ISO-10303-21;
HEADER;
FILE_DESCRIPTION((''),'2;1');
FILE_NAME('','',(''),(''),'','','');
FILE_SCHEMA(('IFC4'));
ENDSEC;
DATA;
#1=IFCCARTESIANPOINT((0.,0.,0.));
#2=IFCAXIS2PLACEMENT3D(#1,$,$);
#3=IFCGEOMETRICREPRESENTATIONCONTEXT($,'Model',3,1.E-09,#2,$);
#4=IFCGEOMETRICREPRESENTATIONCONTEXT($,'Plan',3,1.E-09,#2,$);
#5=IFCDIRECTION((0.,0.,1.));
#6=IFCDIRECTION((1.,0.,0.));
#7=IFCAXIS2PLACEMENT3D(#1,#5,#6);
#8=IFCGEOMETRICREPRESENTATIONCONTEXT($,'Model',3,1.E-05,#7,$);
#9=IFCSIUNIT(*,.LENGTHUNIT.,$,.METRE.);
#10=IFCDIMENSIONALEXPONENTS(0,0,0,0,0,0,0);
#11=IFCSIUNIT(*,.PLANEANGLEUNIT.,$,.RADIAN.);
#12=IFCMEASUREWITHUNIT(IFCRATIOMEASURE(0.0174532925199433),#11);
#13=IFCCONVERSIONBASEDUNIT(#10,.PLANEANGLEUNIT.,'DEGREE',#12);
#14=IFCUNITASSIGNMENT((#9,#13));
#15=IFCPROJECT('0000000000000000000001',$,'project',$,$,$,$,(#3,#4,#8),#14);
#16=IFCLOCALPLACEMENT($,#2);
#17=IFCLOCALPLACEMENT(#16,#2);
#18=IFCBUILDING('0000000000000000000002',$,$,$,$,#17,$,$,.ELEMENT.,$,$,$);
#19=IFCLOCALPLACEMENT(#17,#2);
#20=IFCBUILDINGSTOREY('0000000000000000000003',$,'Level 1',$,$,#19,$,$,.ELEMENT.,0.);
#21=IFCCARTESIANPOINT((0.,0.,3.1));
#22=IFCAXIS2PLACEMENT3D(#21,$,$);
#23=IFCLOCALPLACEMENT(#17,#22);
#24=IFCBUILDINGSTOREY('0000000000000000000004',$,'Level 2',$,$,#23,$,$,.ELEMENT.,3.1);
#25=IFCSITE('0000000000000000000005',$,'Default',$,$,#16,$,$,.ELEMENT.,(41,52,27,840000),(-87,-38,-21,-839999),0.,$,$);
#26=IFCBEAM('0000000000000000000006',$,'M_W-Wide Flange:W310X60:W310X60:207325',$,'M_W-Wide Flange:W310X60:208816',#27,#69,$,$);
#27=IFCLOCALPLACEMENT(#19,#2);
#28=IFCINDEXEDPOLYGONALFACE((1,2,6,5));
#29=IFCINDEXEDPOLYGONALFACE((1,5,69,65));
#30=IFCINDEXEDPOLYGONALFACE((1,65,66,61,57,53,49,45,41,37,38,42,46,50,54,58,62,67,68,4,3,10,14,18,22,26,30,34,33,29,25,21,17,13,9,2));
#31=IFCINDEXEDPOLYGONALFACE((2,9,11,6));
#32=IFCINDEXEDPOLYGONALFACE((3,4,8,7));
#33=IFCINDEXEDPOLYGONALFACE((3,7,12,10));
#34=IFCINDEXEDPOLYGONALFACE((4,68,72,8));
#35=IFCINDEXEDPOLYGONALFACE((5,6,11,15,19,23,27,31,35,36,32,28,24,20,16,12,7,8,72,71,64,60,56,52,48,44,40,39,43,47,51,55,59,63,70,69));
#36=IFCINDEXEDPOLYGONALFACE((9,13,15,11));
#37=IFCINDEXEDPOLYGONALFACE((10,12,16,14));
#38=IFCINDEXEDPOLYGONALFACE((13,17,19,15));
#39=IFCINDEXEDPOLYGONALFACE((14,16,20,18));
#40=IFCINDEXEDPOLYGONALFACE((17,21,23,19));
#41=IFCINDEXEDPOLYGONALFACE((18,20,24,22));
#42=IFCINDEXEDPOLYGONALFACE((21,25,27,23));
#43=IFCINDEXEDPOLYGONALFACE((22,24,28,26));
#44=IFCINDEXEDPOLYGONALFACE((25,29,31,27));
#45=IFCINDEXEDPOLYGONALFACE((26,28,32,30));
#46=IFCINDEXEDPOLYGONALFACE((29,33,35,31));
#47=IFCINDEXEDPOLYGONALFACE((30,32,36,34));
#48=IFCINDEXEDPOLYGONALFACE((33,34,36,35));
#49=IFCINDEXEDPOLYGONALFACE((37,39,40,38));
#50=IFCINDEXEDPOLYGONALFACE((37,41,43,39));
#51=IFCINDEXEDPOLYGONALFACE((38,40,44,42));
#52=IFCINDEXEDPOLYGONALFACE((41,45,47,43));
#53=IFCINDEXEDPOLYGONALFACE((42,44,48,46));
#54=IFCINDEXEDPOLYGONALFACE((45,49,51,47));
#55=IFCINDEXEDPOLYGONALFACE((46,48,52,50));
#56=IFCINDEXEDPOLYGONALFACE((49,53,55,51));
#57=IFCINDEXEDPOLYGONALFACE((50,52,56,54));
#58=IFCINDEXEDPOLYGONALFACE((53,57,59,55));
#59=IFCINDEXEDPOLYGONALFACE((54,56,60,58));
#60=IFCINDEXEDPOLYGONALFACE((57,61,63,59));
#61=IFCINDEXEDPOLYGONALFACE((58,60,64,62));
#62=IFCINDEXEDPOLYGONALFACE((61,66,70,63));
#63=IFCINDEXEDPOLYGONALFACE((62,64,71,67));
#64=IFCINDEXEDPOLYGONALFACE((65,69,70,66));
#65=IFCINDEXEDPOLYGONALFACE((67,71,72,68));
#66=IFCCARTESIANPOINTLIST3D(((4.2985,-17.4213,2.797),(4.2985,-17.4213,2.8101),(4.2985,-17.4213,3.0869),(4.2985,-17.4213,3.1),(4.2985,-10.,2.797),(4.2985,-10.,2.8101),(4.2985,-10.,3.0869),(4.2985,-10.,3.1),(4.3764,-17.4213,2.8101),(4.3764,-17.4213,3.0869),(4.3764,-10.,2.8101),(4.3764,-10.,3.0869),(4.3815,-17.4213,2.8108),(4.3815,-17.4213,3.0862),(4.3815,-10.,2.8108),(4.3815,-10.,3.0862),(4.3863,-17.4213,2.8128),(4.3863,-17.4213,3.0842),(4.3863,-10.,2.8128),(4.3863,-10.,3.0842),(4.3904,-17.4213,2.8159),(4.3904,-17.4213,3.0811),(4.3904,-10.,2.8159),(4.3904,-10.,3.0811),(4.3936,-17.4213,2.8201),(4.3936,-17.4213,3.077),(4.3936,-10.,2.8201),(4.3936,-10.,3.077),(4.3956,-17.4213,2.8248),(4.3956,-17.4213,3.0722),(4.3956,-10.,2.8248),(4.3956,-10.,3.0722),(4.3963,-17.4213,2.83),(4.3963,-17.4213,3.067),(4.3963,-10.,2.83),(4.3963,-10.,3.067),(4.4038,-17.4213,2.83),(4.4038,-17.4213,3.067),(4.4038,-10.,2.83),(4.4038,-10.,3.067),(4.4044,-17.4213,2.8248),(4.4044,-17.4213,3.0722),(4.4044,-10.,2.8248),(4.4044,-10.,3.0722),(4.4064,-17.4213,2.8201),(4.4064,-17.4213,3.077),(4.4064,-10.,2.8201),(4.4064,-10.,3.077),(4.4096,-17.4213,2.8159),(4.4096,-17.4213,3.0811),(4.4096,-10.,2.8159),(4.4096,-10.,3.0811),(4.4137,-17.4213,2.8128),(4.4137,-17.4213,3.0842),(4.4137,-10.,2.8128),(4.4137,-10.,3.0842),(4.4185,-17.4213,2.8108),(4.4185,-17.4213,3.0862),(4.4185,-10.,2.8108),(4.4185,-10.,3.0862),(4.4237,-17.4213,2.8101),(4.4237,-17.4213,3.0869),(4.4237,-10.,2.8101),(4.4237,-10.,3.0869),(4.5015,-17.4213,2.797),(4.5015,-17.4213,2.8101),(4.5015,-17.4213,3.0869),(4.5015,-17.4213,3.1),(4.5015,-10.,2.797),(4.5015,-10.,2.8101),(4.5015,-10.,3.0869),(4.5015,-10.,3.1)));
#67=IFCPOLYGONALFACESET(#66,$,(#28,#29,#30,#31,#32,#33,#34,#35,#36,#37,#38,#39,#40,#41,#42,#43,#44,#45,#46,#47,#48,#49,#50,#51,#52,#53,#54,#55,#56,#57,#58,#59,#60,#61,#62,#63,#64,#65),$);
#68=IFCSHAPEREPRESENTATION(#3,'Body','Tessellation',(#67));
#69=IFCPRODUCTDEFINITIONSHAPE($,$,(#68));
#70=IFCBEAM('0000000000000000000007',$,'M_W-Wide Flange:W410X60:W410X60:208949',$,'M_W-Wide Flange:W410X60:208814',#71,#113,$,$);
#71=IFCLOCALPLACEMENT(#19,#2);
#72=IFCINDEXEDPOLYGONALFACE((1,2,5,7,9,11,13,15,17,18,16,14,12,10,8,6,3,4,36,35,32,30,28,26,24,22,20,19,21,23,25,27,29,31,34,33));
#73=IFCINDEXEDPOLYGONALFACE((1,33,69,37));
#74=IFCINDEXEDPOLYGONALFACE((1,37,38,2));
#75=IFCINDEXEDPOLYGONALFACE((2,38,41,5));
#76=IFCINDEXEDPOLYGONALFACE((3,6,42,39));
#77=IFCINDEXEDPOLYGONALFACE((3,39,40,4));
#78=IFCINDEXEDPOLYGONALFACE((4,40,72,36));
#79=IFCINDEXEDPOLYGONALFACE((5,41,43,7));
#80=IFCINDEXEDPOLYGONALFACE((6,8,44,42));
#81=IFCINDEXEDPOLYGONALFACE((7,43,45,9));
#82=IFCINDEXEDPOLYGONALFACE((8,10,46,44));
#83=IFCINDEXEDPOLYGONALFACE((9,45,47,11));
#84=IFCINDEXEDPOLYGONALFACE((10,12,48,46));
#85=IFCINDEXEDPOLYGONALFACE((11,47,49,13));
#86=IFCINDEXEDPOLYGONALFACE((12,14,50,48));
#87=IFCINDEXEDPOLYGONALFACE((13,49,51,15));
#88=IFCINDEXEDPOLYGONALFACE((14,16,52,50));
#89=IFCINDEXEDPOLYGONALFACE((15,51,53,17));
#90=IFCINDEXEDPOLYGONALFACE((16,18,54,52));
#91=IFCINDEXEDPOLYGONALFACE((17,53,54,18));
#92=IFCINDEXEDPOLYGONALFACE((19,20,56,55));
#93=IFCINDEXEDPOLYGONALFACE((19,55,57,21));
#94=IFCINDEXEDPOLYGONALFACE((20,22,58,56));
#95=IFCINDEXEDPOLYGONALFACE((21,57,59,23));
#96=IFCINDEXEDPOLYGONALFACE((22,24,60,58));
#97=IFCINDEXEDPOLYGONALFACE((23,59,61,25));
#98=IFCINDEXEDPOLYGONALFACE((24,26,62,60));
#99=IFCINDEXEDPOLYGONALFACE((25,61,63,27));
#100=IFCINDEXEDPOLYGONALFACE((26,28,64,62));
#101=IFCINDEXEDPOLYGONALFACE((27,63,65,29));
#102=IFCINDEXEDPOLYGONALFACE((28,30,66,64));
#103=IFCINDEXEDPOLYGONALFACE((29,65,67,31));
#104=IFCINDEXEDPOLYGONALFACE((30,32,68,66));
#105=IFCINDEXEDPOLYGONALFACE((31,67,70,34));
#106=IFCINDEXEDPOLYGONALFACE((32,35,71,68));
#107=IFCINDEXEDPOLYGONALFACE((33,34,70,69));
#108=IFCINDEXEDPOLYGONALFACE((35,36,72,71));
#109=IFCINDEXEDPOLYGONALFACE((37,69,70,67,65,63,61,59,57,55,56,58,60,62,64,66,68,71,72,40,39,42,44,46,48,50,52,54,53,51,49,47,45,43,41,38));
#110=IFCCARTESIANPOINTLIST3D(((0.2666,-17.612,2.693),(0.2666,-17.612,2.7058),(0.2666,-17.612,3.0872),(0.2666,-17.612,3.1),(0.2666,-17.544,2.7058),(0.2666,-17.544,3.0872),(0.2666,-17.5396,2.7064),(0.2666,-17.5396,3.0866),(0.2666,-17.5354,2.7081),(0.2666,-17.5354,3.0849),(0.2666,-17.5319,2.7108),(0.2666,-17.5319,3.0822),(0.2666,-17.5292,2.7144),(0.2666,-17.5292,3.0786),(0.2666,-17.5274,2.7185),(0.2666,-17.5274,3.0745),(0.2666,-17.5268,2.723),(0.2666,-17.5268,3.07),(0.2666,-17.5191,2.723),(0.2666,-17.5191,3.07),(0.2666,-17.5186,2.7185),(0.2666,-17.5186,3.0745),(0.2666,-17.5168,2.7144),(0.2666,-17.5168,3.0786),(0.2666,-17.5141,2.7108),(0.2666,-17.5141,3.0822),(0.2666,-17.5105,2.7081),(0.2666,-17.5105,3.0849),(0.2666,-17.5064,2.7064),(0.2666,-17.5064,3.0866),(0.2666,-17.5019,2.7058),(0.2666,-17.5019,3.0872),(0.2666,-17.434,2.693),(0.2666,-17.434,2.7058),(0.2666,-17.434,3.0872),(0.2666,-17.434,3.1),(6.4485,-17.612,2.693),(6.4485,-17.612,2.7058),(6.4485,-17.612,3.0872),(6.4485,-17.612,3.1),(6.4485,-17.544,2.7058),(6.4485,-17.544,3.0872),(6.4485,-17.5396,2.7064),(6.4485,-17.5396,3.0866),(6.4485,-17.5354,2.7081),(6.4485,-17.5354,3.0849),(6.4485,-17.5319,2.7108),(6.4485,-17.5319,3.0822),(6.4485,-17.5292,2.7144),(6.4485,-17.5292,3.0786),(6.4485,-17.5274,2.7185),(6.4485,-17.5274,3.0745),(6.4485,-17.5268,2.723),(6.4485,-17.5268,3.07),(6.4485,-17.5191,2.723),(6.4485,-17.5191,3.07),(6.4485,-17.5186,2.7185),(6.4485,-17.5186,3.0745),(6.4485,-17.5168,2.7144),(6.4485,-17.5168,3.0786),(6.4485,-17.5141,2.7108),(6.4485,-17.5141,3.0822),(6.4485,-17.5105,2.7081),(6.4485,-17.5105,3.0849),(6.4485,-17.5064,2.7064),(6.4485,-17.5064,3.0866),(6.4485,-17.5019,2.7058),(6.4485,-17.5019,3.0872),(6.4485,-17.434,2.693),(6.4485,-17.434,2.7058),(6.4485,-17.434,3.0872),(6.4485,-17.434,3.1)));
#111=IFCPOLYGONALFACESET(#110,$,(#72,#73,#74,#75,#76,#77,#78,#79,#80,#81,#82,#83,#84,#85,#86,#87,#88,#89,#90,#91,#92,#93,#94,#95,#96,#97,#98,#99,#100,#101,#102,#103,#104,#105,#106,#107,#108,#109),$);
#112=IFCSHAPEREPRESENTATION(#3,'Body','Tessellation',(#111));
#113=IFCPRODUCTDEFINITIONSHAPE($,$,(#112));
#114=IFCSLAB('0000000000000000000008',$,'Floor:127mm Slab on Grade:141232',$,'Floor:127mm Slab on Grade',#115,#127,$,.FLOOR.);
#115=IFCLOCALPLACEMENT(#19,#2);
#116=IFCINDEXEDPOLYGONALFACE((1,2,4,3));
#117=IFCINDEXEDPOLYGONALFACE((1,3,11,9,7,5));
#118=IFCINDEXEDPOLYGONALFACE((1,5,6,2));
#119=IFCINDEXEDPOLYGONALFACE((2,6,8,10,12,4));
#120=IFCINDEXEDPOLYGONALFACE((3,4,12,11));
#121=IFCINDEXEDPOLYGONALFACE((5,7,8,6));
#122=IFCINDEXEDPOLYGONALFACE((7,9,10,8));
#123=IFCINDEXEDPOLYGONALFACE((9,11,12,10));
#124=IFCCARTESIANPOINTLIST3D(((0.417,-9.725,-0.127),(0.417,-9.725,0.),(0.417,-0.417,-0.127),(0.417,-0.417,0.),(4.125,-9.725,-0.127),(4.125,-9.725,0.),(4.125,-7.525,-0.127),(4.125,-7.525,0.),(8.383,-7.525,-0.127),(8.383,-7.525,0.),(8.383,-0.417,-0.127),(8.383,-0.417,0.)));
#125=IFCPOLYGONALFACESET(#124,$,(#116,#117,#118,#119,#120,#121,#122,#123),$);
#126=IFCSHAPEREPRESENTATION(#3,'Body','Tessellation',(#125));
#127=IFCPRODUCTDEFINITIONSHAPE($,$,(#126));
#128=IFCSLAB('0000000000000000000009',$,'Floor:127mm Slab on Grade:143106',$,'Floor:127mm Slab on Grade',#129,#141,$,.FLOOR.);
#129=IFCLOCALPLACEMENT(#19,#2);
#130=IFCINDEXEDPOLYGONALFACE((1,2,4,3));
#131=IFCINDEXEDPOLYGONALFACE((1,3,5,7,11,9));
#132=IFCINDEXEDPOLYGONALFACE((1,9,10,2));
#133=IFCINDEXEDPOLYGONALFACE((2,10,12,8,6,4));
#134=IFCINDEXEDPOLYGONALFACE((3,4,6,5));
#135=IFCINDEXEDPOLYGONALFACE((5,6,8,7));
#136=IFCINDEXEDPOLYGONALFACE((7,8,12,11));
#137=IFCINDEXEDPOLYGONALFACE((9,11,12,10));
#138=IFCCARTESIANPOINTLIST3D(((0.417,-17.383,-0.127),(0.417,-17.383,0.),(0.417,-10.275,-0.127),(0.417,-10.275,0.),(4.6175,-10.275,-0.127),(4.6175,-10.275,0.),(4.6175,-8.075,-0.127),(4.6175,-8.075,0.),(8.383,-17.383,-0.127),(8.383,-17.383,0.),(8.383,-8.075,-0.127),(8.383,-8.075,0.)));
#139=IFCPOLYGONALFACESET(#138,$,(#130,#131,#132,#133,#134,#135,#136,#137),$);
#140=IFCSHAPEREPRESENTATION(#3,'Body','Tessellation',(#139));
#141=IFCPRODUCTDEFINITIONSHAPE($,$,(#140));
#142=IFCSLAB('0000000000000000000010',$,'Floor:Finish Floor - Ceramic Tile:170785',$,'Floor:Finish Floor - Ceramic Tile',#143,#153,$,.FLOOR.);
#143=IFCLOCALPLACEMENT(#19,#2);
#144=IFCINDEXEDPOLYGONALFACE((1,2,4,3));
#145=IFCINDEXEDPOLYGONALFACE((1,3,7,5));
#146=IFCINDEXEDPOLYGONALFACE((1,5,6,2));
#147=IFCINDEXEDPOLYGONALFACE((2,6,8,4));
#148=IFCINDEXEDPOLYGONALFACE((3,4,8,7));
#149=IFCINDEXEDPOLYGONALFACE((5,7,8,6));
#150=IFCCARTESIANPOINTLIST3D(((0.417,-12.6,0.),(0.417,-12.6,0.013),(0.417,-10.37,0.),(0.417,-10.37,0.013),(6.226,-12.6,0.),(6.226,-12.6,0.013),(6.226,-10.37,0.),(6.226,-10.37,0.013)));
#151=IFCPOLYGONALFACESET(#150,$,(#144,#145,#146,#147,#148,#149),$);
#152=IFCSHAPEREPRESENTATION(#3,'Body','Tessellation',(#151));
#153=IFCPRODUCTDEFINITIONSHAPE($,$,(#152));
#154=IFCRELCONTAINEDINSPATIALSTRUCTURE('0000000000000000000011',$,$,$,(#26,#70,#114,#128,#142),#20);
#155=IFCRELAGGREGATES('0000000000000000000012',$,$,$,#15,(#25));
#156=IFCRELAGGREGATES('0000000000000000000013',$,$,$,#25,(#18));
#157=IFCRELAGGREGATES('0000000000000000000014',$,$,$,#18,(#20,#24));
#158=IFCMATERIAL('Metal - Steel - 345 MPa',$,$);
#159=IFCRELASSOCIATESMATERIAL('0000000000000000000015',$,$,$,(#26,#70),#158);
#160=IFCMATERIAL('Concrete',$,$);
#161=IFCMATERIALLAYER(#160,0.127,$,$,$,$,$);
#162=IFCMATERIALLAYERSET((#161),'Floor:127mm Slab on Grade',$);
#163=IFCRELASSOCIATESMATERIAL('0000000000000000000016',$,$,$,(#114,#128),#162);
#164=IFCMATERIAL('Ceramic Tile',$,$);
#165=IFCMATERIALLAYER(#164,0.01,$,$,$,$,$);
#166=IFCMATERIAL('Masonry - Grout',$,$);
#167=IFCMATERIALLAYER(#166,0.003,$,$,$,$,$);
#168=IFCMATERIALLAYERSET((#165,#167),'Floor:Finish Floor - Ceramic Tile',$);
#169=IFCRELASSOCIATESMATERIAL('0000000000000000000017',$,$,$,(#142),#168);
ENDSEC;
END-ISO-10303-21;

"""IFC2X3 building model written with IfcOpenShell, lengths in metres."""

from ifc_helpers import new_model, entity, si_unit, converted_unit, frame, frame_2d, origin, origin_with_axes, place, context, project, spatial, polyline, circle_curve, parameter, trimmed, segment, composite_curve, rectangle, outline, extrude, material, layer, layer_set, layer_usage, element, save


model = new_model("IFC2X3")

# Units and contexts
model_context_1 = context("Model", 3, precision=1e-09, world=origin())
plan_context = context("Plan", 3, precision=1e-09, world=origin())
model_context_2 = context("Model", 3, precision=1e-05, world=origin_with_axes())
ifc_project = project(units=[si_unit("LENGTHUNIT", "METRE"), converted_unit("PLANEANGLEUNIT", "DEGREE", entity("IfcRatioMeasure", 0.0174532925199433), si_unit("PLANEANGLEUNIT", "RADIAN"), dimensions=[0, 0, 0, 0, 0, 0, 0])], contexts=[model_context_1, plan_context, model_context_2])

# Site, building, storey
site_placement = place(None, origin())
site = spatial("IfcSite", under=ifc_project, at=site_placement, Name="Default", CompositionType="ELEMENT", RefLatitude=(41, 52, 27, 840000), RefLongitude=(-87, -38, -21, -839999), RefElevation=0.0)
building_placement = place(site_placement, origin())
building = spatial("IfcBuilding", under=site, at=building_placement, CompositionType="ELEMENT")
storey_1_placement = place(building_placement, origin())
storey_1 = spatial("IfcBuildingStorey", under=building, at=storey_1_placement, Name="Level 1", CompositionType="ELEMENT", Elevation=0.0)

# Beams
ifc_material_1 = material(Name="Metal - Steel - 345 MPa")
beam_1_placement = place(storey_1_placement, frame((4.4, -10.0, 3.1), z_axis=(0.0, 0.0, 1.0), x_axis=(-1.0, 0.0, 0.0)))
element("IfcBeam", 1, at=beam_1_placement, inside=storey_1, material=ifc_material_1, Name="M_W-Wide Flange:W310X60:W310X60:207325", ObjectType="M_W-Wide Flange:W310X60:208816", context=model_context_1, shape_type="SweptSolid", body=[
    extrude(outline(composite_curve([segment(polyline([(0.1384, -0.1015), (0.1515, -0.1015)]), True, "CONTINUOUS"), segment(polyline([(0.1515, -0.1015), (0.1515, 0.1015)]), True, "CONTINUOUS"), segment(polyline([(0.1515, 0.1015), (0.1384, 0.1015)]), True, "CONTINUOUS"), segment(polyline([(0.1384, 0.1015), (0.1384, 0.0236)]), True, "CONTINUOUS"), segment(trimmed(circle_curve(frame_2d((0.1185, 0.0236), x_axis=(0.0, 1.0)), 0.0199), [parameter(180.0)], [parameter(270.0)], True, "PARAMETER"), False, "CONTINUOUS"), segment(polyline([(0.1185, 0.0037), (-0.1185, 0.0037)]), True, "CONTINUOUS"), segment(trimmed(circle_curve(frame_2d((-0.1185, 0.0236), x_axis=(0.0, 1.0)), 0.0199), [parameter(90.0)], [parameter(180.0)], True, "PARAMETER"), False, "CONTINUOUS"), segment(polyline([(-0.1384, 0.0236), (-0.1384, 0.1015)]), True, "CONTINUOUS"), segment(polyline([(-0.1384, 0.1015), (-0.1515, 0.1015)]), True, "CONTINUOUS"), segment(polyline([(-0.1515, 0.1015), (-0.1515, -0.1015)]), True, "CONTINUOUS"), segment(polyline([(-0.1515, -0.1015), (-0.1384, -0.1015)]), True, "CONTINUOUS"), segment(polyline([(-0.1384, -0.1015), (-0.1384, -0.0237)]), True, "CONTINUOUS"), segment(trimmed(circle_curve(frame_2d((-0.1185, -0.0237), x_axis=(0.0, 1.0)), 0.0199), [parameter(360.0)], [parameter(90.0)], True, "PARAMETER"), False, "CONTINUOUS"), segment(polyline([(-0.1185, -0.0038), (0.1185, -0.0038)]), True, "CONTINUOUS"), segment(trimmed(circle_curve(frame_2d((0.1185, -0.0237), x_axis=(0.0, 1.0)), 0.0199), [parameter(270.0)], [parameter(0.0)], True, "PARAMETER"), False, "CONTINUOUS"), segment(polyline([(0.1384, -0.0237), (0.1384, -0.1015)]), True, "CONTINUOUS")], self_intersect=False)), frame((0.0, 7.4213, -0.1515), z_axis=(0.0, -1.0, 0.0), x_axis=(0.0, 0.0, -1.0)), (0.0, 0.0, 1.0), 7.4213),
])
beam_2_placement = place(storey_1_placement, frame((0.2085, -17.523, 3.1), z_axis=(0.0, 0.0, 1.0), x_axis=(0.0, -1.0, 0.0)))
element("IfcBeam", 2, at=beam_2_placement, inside=storey_1, material=ifc_material_1, Name="M_W-Wide Flange:W410X60:W410X60:208949", ObjectType="M_W-Wide Flange:W410X60:208814", context=model_context_1, shape_type="SweptSolid", body=[
    extrude(outline(composite_curve([segment(polyline([(-0.089, -0.1907), (-0.089, -0.2035)]), True, "CONTINUOUS"), segment(polyline([(-0.089, -0.2035), (0.089, -0.2035)]), True, "CONTINUOUS"), segment(polyline([(0.089, -0.2035), (0.089, -0.1907)]), True, "CONTINUOUS"), segment(polyline([(0.089, -0.1907), (0.021, -0.1907)]), True, "CONTINUOUS"), segment(trimmed(circle_curve(frame_2d((0.021, -0.1735), x_axis=(0.0, -1.0)), 0.0172), [parameter(270.0)], [parameter(360.0)], True, "PARAMETER"), False, "CONTINUOUS"), segment(polyline([(0.0038, -0.1735), (0.0038, 0.1735)]), True, "CONTINUOUS"), segment(trimmed(circle_curve(frame_2d((0.021, 0.1735), x_axis=(-1.0, 0.0)), 0.0172), [parameter(270.0)], [parameter(360.0)], True, "PARAMETER"), False, "CONTINUOUS"), segment(polyline([(0.021, 0.1907), (0.089, 0.1907)]), True, "CONTINUOUS"), segment(polyline([(0.089, 0.1907), (0.089, 0.2035)]), True, "CONTINUOUS"), segment(polyline([(0.089, 0.2035), (-0.089, 0.2035)]), True, "CONTINUOUS"), segment(polyline([(-0.089, 0.2035), (-0.089, 0.1907)]), True, "CONTINUOUS"), segment(polyline([(-0.089, 0.1907), (-0.0211, 0.1907)]), True, "CONTINUOUS"), segment(trimmed(circle_curve(frame_2d((-0.0211, 0.1735), x_axis=(0.0, 1.0)), 0.0172), [parameter(270.0)], [parameter(0.0)], True, "PARAMETER"), False, "CONTINUOUS"), segment(polyline([(-0.0039, 0.1735), (-0.0039, -0.1735)]), True, "CONTINUOUS"), segment(trimmed(circle_curve(frame_2d((-0.0211, -0.1735), x_axis=(1.0, 0.0)), 0.0172), [parameter(270.0)], [parameter(0.0)], True, "PARAMETER"), False, "CONTINUOUS"), segment(polyline([(-0.0211, -0.1907), (-0.089, -0.1907)]), True, "CONTINUOUS")], self_intersect=False)), frame((0.0, 0.0581, -0.2035), z_axis=(0.0, -1.0, 0.0), x_axis=(1.0, 0.0, 0.0)), (0.0, 0.0, -1.0), 6.1819),
])

# Slabs
ifc_material_2 = material(Name="Concrete")
ifc_layer_1 = layer(ifc_material_2, 0.127)
ifc_layer_set_1 = layer_set([ifc_layer_1], Name="Floor:127mm Slab on Grade")
ifc_layer_usage_1 = layer_usage(ifc_layer_set_1, "AXIS3", "POSITIVE", 0.0)
slab_1_placement = place(storey_1_placement, frame((0.417, -9.725, -0.127)))
element("IfcSlab", 3, at=slab_1_placement, inside=storey_1, material=ifc_layer_usage_1, Name="Floor:127mm Slab on Grade:141232", ObjectType="Floor:127mm Slab on Grade", PredefinedType="FLOOR", context=model_context_1, shape_type="SweptSolid", body=[
    extrude(outline(polyline([(-3.983, 4.654), (-3.983, -2.454), (0.275, -2.454), (0.275, -4.654), (3.983, -4.654), (3.983, 4.654), (-3.983, 4.654)])), frame((3.983, 4.654, 0.127), z_axis=(0.0, 0.0, -1.0), x_axis=(-1.0, 0.0, 0.0)), (0.0, 0.0, 1.0), 0.127),
])
ifc_layer_usage_2 = layer_usage(ifc_layer_set_1, "AXIS3", "POSITIVE", 0.0)
slab_2_placement = place(storey_1_placement, frame((0.417, -17.383, -0.127)))
element("IfcSlab", 4, at=slab_2_placement, inside=storey_1, material=ifc_layer_usage_2, Name="Floor:127mm Slab on Grade:143106", ObjectType="Floor:127mm Slab on Grade", PredefinedType="FLOOR", context=model_context_1, shape_type="SweptSolid", body=[
    extrude(outline(polyline([(-3.983, 4.654), (-3.983, -4.654), (3.983, -4.654), (3.983, 2.454), (-0.2175, 2.454), (-0.2175, 4.654), (-3.983, 4.654)])), frame((3.983, 4.654, 0.127), z_axis=(0.0, 0.0, -1.0), x_axis=(-1.0, 0.0, 0.0)), (0.0, 0.0, 1.0), 0.127),
])
ifc_material_3 = material(Name="Ceramic Tile")
ifc_layer_2 = layer(ifc_material_3, 0.01)
ifc_material_4 = material(Name="Masonry - Grout")
ifc_layer_3 = layer(ifc_material_4, 0.003)
ifc_layer_set_2 = layer_set([ifc_layer_2, ifc_layer_3], Name="Floor:Finish Floor - Ceramic Tile")
ifc_layer_usage_3 = layer_usage(ifc_layer_set_2, "AXIS3", "POSITIVE", 0.0)
slab_3_placement = place(storey_1_placement, frame((0.417, -12.6, 0.0)))
element("IfcSlab", 5, at=slab_3_placement, inside=storey_1, material=ifc_layer_usage_3, Name="Floor:Finish Floor - Ceramic Tile:170785", ObjectType="Floor:Finish Floor - Ceramic Tile", PredefinedType="FLOOR", context=model_context_1, shape_type="SweptSolid", body=[
    extrude(rectangle(XDim=5.809, YDim=2.23, at=frame_2d((0.0, 0.0), x_axis=(-1.0, 0.0))), frame((2.9045, 1.115, 0.013), z_axis=(0.0, 0.0, -1.0), x_axis=(-1.0, 0.0, 0.0)), (0.0, 0.0, 1.0), 0.013),
])

# Shared definitions
storey_2_placement = place(building_placement, frame((0.0, 0.0, 3.1)))
storey_2 = spatial("IfcBuildingStorey", under=building, at=storey_2_placement, Name="Level 2", CompositionType="ELEMENT", Elevation=3.1)

save(model, "model.ifc")
